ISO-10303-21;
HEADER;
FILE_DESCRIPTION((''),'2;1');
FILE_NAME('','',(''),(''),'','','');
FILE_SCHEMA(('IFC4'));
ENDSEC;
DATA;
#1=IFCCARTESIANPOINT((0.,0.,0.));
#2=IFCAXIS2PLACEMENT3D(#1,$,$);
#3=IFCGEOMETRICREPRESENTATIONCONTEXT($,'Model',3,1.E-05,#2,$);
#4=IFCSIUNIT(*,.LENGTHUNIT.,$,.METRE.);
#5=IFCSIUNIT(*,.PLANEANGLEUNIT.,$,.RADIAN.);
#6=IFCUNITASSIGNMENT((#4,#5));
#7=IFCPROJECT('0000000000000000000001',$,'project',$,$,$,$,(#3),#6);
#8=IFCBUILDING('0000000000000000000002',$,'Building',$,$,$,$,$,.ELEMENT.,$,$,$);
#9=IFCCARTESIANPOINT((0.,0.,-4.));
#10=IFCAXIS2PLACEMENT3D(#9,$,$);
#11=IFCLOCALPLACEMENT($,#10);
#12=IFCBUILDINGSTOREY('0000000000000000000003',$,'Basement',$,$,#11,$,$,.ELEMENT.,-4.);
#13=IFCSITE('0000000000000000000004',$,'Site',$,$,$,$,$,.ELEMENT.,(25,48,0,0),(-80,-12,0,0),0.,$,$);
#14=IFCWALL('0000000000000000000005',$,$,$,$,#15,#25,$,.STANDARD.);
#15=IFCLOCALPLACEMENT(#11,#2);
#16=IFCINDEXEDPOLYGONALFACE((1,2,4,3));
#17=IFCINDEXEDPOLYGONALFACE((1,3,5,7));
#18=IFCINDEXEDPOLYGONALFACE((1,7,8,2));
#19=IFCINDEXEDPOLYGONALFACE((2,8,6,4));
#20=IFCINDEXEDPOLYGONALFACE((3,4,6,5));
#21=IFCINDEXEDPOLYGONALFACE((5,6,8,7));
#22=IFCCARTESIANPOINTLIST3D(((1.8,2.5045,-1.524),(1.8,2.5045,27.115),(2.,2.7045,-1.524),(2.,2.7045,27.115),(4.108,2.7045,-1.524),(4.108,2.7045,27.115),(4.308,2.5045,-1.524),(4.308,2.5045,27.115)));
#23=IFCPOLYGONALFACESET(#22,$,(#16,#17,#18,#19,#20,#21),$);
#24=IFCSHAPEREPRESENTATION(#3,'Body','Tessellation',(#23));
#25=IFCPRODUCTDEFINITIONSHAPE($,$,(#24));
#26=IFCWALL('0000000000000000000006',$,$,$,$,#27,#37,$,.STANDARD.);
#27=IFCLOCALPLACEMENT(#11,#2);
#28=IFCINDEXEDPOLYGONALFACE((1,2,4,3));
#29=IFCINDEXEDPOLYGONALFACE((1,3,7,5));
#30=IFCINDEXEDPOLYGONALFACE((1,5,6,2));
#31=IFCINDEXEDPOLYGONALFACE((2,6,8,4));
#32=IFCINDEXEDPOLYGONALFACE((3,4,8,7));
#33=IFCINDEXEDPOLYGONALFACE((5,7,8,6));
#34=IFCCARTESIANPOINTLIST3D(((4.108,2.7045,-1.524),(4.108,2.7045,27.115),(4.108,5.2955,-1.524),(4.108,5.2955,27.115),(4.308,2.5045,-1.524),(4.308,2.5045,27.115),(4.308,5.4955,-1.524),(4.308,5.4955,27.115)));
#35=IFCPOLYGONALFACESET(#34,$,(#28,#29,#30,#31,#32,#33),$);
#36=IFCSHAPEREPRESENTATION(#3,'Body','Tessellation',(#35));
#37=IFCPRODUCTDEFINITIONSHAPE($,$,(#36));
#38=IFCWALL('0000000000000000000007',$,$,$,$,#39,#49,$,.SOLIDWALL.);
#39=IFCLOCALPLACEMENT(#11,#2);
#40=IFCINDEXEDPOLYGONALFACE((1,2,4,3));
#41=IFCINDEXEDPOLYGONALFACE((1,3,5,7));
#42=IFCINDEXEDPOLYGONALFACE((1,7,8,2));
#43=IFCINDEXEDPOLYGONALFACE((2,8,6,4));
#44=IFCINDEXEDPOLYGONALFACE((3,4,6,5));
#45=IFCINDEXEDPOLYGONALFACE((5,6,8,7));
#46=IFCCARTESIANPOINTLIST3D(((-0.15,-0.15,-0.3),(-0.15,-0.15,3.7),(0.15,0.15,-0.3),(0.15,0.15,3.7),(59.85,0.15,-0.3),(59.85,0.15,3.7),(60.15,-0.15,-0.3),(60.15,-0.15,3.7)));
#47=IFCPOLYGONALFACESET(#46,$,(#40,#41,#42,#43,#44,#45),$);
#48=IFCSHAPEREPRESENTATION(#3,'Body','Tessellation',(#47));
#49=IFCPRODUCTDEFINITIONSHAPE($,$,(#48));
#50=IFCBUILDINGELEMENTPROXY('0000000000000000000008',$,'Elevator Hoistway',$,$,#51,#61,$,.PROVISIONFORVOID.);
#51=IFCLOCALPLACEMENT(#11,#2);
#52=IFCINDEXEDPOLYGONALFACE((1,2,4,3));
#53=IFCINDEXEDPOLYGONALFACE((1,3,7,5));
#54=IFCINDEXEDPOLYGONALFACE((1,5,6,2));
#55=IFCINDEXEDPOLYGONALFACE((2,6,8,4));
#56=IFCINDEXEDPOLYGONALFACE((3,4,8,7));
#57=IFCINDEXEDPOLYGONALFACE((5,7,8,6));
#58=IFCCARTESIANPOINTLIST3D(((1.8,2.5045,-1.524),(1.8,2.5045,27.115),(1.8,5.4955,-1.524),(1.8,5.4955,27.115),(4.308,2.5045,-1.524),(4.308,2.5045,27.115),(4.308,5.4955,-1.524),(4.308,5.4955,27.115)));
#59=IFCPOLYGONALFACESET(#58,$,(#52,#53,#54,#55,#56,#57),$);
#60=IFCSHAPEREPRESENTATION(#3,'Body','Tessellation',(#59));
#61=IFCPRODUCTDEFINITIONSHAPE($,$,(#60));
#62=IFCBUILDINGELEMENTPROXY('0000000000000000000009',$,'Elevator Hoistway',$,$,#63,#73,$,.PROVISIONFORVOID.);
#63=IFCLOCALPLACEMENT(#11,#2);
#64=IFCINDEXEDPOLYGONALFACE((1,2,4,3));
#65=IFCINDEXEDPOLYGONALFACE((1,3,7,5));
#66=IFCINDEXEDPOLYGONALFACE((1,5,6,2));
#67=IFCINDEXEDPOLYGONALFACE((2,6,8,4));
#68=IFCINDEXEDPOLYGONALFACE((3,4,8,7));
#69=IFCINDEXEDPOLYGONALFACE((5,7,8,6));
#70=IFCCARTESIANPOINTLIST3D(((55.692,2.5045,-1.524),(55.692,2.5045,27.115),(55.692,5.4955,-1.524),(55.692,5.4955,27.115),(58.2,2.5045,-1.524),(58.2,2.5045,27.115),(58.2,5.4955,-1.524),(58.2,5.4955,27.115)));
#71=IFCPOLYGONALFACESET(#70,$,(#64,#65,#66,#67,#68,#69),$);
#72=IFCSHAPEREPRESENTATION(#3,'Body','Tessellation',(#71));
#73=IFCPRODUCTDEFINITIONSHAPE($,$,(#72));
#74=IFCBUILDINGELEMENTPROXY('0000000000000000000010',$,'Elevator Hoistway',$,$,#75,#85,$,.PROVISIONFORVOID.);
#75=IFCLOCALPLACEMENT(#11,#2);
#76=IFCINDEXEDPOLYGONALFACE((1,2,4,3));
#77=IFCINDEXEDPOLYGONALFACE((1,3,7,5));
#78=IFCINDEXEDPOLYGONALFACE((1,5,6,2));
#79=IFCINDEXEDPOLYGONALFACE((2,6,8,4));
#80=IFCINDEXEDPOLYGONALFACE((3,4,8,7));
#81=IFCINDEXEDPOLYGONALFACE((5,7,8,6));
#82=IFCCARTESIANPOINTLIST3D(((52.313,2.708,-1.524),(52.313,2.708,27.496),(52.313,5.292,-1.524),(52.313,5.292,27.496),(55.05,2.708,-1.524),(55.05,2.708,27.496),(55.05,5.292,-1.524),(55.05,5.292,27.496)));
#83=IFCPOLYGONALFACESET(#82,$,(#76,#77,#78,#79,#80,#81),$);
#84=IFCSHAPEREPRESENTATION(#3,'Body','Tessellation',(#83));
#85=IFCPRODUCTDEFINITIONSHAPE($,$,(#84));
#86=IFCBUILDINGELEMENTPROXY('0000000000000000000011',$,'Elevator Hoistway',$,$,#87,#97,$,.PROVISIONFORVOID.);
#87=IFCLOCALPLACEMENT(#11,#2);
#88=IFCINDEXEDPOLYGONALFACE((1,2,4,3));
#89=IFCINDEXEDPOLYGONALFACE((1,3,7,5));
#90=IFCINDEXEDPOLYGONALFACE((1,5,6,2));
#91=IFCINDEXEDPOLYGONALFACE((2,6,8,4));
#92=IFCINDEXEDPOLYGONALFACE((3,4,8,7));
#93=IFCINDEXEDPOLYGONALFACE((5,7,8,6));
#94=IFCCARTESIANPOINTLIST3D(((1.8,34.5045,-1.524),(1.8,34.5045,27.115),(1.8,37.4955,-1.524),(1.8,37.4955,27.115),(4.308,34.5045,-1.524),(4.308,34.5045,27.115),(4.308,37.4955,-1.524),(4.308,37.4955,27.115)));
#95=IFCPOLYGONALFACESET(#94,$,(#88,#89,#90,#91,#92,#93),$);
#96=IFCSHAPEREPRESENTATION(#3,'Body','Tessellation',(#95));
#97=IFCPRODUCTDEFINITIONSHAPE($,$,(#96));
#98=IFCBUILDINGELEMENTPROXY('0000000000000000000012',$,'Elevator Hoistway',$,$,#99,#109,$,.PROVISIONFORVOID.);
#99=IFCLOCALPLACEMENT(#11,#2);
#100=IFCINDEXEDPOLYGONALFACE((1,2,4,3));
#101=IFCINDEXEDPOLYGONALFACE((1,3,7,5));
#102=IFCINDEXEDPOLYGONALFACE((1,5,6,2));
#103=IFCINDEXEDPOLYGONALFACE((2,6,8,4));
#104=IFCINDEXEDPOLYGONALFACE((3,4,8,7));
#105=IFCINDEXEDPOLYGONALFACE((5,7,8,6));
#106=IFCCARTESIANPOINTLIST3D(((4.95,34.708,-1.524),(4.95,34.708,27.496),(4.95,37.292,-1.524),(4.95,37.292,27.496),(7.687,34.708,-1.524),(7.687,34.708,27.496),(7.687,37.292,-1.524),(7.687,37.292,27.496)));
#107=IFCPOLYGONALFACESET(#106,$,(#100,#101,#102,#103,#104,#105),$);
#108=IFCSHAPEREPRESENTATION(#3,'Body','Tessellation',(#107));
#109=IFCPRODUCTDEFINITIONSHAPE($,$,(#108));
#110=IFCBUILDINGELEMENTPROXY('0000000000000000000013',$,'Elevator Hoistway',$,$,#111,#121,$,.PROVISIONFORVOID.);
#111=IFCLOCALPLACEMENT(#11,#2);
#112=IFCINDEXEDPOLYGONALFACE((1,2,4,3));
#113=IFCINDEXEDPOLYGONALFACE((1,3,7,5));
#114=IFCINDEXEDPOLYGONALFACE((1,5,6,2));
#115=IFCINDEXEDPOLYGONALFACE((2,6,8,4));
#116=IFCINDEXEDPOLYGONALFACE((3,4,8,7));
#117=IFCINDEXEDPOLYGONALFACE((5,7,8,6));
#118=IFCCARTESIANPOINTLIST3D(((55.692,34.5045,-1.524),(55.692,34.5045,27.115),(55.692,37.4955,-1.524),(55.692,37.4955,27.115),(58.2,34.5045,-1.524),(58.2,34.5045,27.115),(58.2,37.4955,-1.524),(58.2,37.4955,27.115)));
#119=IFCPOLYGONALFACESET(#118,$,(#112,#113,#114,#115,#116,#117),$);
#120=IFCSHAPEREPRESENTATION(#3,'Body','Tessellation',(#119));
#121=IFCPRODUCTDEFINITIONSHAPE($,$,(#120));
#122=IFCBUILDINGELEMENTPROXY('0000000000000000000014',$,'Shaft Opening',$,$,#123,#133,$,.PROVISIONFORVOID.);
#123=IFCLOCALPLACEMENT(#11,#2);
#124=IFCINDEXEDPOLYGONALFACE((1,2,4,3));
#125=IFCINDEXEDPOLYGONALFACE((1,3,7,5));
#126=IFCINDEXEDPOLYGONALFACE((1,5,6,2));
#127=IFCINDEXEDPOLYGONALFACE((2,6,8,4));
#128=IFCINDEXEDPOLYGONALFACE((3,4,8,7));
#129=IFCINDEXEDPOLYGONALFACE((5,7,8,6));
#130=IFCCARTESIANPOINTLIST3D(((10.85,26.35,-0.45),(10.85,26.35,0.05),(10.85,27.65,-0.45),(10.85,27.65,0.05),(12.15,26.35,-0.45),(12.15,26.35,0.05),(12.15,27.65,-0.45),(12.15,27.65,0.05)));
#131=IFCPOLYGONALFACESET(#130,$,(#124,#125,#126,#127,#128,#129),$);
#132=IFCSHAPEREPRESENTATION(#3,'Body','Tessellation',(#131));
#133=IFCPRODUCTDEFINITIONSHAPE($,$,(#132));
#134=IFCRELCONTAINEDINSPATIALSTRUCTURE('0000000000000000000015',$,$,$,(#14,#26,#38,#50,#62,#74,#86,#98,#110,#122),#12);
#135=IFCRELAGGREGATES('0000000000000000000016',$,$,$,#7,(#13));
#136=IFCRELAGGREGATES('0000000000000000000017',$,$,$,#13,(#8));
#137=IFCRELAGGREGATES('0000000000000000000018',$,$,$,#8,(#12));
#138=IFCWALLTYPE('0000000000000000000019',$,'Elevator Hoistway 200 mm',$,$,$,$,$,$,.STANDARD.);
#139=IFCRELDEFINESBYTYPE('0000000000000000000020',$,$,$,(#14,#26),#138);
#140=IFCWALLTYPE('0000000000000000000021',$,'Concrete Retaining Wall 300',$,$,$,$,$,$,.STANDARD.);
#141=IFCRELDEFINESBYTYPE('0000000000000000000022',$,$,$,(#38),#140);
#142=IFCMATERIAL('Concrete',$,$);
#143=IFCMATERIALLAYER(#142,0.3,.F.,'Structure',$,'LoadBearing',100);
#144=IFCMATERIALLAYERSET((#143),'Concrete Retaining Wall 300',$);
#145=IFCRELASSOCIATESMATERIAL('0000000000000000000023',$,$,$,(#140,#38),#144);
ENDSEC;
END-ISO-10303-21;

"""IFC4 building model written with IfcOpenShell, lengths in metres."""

from ifc_helpers import new_model, si_unit, frame, origin, place, context, project, spatial, polyline, outline, extrude, material, layer, layer_set, layer_usage, type_object, element, save


model = new_model("IFC4")

# Units and contexts
model_context = context("Model", 3, precision=1e-05, world=origin())
ifc_project = project(units=[si_unit("LENGTHUNIT", "METRE"), si_unit("PLANEANGLEUNIT", "RADIAN")], contexts=[model_context])

# Site, building, storey
site = spatial("IfcSite", under=ifc_project, Name="Site", CompositionType="ELEMENT", RefLatitude=(25, 48, 0, 0), RefLongitude=(-80, -12, 0, 0), RefElevation=0.0)
building = spatial("IfcBuilding", under=site, Name="Building", CompositionType="ELEMENT")
storey_placement = place(None, frame((0.0, 0.0, -4.0)))
storey = spatial("IfcBuildingStorey", under=building, at=storey_placement, Name="Basement", CompositionType="ELEMENT", Elevation=-4.0)

# Walls
wall_type_1 = type_object("IfcWallType", Name="Elevator Hoistway 200 mm", PredefinedType="STANDARD")
wall_1_placement = place(None, frame((1.9, 2.6045, -5.524), z_axis=(0.0, 0.0, 1.0), x_axis=(1.0, 0.0, 0.0)))
element("IfcWall", 1, at=wall_1_placement, inside=storey, type_object=wall_type_1, PredefinedType="STANDARD", context=model_context, shape_type="SweptSolid", body=[
    extrude(outline(polyline([(-0.1, -0.1), (2.408, -0.1), (2.208, 0.1), (0.1, 0.1), (-0.1, -0.1)])), origin(), (0.0, 0.0, 1.0), 28.639),
])
wall_2_placement = place(None, frame((4.208, 2.6045, -5.524), z_axis=(0.0, 0.0, 1.0), x_axis=(0.0, 1.0, 0.0)))
element("IfcWall", 2, at=wall_2_placement, inside=storey, type_object=wall_type_1, PredefinedType="STANDARD", context=model_context, shape_type="SweptSolid", body=[
    extrude(outline(polyline([(-0.1, -0.1), (2.891, -0.1), (2.691, 0.1), (0.1, 0.1), (-0.1, -0.1)])), origin(), (0.0, 0.0, 1.0), 28.639),
])
ifc_material = material(Name="Concrete")
ifc_layer = layer(ifc_material, 0.3, ventilated=False, Name="Structure", Category="LoadBearing", Priority=100)
ifc_layer_set = layer_set([ifc_layer], Name="Concrete Retaining Wall 300")
ifc_layer_usage = layer_usage(ifc_layer_set, "AXIS2", "POSITIVE", -0.15)
wall_type_2 = type_object("IfcWallType", Name="Concrete Retaining Wall 300", PredefinedType="STANDARD", material=ifc_layer_set)
wall_3_placement = place(None, frame((0.0, 0.0, -4.3), z_axis=(0.0, 0.0, 1.0), x_axis=(1.0, 0.0, 0.0)))
element("IfcWall", 3, at=wall_3_placement, inside=storey, type_object=wall_type_2, material=ifc_layer_usage, PredefinedType="SOLIDWALL", context=model_context, shape_type="SweptSolid", body=[
    extrude(outline(polyline([(-0.15, -0.15), (60.15, -0.15), (59.85, 0.15), (0.15, 0.15), (-0.15, -0.15)])), origin(), (0.0, 0.0, 1.0), 4.0),
])

# Building element proxies
proxy_1_placement = place(None, frame((0.0, 0.0, 23.115)))
element("IfcBuildingElementProxy", 4, at=proxy_1_placement, inside=storey, Name="Elevator Hoistway", PredefinedType="PROVISIONFORVOID", context=model_context, shape_type="SweptSolid", body=[
    extrude(outline(polyline([(1.8, 5.4955), (1.8, 2.5045), (4.308, 2.5045), (4.308, 5.4955), (1.8, 5.4955)])), origin(), (0.0, 0.0, -1.0), 28.639),
])
proxy_2_placement = place(None, frame((0.0, 0.0, 23.115)))
element("IfcBuildingElementProxy", 5, at=proxy_2_placement, inside=storey, Name="Elevator Hoistway", PredefinedType="PROVISIONFORVOID", context=model_context, shape_type="SweptSolid", body=[
    extrude(outline(polyline([(58.2, 2.5045), (58.2, 5.4955), (55.692, 5.4955), (55.692, 2.5045), (58.2, 2.5045)])), origin(), (0.0, 0.0, -1.0), 28.639),
])
proxy_3_placement = place(None, frame((0.0, 0.0, 23.496)))
element("IfcBuildingElementProxy", 6, at=proxy_3_placement, inside=storey, Name="Elevator Hoistway", PredefinedType="PROVISIONFORVOID", context=model_context, shape_type="SweptSolid", body=[
    extrude(outline(polyline([(55.05, 2.708), (55.05, 5.292), (52.313, 5.292), (52.313, 2.708), (55.05, 2.708)])), origin(), (0.0, 0.0, -1.0), 29.02),
])
proxy_4_placement = place(None, frame((0.0, 0.0, 23.115)))
element("IfcBuildingElementProxy", 7, at=proxy_4_placement, inside=storey, Name="Elevator Hoistway", PredefinedType="PROVISIONFORVOID", context=model_context, shape_type="SweptSolid", body=[
    extrude(outline(polyline([(1.8, 37.4955), (1.8, 34.5045), (4.308, 34.5045), (4.308, 37.4955), (1.8, 37.4955)])), origin(), (0.0, 0.0, -1.0), 28.639),
])
proxy_5_placement = place(None, frame((0.0, 0.0, 23.496)))
element("IfcBuildingElementProxy", 8, at=proxy_5_placement, inside=storey, Name="Elevator Hoistway", PredefinedType="PROVISIONFORVOID", context=model_context, shape_type="SweptSolid", body=[
    extrude(outline(polyline([(4.95, 37.292), (4.95, 34.708), (7.687, 34.708), (7.687, 37.292), (4.95, 37.292)])), origin(), (0.0, 0.0, -1.0), 29.02),
])
proxy_6_placement = place(None, frame((0.0, 0.0, 23.115)))
element("IfcBuildingElementProxy", 9, at=proxy_6_placement, inside=storey, Name="Elevator Hoistway", PredefinedType="PROVISIONFORVOID", context=model_context, shape_type="SweptSolid", body=[
    extrude(outline(polyline([(58.2, 34.5045), (58.2, 37.4955), (55.692, 37.4955), (55.692, 34.5045), (58.2, 34.5045)])), origin(), (0.0, 0.0, -1.0), 28.639),
])
proxy_7_placement = place(None, frame((0.0, 0.0, -3.95)))
element("IfcBuildingElementProxy", 10, at=proxy_7_placement, inside=storey, Name="Shaft Opening", PredefinedType="PROVISIONFORVOID", context=model_context, shape_type="SweptSolid", body=[
    extrude(outline(polyline([(10.85, 26.35), (12.15, 26.35), (12.15, 27.65), (10.85, 27.65), (10.85, 26.35)])), origin(), (0.0, 0.0, -1.0), 0.5),
])

save(model, "model.ifc")
